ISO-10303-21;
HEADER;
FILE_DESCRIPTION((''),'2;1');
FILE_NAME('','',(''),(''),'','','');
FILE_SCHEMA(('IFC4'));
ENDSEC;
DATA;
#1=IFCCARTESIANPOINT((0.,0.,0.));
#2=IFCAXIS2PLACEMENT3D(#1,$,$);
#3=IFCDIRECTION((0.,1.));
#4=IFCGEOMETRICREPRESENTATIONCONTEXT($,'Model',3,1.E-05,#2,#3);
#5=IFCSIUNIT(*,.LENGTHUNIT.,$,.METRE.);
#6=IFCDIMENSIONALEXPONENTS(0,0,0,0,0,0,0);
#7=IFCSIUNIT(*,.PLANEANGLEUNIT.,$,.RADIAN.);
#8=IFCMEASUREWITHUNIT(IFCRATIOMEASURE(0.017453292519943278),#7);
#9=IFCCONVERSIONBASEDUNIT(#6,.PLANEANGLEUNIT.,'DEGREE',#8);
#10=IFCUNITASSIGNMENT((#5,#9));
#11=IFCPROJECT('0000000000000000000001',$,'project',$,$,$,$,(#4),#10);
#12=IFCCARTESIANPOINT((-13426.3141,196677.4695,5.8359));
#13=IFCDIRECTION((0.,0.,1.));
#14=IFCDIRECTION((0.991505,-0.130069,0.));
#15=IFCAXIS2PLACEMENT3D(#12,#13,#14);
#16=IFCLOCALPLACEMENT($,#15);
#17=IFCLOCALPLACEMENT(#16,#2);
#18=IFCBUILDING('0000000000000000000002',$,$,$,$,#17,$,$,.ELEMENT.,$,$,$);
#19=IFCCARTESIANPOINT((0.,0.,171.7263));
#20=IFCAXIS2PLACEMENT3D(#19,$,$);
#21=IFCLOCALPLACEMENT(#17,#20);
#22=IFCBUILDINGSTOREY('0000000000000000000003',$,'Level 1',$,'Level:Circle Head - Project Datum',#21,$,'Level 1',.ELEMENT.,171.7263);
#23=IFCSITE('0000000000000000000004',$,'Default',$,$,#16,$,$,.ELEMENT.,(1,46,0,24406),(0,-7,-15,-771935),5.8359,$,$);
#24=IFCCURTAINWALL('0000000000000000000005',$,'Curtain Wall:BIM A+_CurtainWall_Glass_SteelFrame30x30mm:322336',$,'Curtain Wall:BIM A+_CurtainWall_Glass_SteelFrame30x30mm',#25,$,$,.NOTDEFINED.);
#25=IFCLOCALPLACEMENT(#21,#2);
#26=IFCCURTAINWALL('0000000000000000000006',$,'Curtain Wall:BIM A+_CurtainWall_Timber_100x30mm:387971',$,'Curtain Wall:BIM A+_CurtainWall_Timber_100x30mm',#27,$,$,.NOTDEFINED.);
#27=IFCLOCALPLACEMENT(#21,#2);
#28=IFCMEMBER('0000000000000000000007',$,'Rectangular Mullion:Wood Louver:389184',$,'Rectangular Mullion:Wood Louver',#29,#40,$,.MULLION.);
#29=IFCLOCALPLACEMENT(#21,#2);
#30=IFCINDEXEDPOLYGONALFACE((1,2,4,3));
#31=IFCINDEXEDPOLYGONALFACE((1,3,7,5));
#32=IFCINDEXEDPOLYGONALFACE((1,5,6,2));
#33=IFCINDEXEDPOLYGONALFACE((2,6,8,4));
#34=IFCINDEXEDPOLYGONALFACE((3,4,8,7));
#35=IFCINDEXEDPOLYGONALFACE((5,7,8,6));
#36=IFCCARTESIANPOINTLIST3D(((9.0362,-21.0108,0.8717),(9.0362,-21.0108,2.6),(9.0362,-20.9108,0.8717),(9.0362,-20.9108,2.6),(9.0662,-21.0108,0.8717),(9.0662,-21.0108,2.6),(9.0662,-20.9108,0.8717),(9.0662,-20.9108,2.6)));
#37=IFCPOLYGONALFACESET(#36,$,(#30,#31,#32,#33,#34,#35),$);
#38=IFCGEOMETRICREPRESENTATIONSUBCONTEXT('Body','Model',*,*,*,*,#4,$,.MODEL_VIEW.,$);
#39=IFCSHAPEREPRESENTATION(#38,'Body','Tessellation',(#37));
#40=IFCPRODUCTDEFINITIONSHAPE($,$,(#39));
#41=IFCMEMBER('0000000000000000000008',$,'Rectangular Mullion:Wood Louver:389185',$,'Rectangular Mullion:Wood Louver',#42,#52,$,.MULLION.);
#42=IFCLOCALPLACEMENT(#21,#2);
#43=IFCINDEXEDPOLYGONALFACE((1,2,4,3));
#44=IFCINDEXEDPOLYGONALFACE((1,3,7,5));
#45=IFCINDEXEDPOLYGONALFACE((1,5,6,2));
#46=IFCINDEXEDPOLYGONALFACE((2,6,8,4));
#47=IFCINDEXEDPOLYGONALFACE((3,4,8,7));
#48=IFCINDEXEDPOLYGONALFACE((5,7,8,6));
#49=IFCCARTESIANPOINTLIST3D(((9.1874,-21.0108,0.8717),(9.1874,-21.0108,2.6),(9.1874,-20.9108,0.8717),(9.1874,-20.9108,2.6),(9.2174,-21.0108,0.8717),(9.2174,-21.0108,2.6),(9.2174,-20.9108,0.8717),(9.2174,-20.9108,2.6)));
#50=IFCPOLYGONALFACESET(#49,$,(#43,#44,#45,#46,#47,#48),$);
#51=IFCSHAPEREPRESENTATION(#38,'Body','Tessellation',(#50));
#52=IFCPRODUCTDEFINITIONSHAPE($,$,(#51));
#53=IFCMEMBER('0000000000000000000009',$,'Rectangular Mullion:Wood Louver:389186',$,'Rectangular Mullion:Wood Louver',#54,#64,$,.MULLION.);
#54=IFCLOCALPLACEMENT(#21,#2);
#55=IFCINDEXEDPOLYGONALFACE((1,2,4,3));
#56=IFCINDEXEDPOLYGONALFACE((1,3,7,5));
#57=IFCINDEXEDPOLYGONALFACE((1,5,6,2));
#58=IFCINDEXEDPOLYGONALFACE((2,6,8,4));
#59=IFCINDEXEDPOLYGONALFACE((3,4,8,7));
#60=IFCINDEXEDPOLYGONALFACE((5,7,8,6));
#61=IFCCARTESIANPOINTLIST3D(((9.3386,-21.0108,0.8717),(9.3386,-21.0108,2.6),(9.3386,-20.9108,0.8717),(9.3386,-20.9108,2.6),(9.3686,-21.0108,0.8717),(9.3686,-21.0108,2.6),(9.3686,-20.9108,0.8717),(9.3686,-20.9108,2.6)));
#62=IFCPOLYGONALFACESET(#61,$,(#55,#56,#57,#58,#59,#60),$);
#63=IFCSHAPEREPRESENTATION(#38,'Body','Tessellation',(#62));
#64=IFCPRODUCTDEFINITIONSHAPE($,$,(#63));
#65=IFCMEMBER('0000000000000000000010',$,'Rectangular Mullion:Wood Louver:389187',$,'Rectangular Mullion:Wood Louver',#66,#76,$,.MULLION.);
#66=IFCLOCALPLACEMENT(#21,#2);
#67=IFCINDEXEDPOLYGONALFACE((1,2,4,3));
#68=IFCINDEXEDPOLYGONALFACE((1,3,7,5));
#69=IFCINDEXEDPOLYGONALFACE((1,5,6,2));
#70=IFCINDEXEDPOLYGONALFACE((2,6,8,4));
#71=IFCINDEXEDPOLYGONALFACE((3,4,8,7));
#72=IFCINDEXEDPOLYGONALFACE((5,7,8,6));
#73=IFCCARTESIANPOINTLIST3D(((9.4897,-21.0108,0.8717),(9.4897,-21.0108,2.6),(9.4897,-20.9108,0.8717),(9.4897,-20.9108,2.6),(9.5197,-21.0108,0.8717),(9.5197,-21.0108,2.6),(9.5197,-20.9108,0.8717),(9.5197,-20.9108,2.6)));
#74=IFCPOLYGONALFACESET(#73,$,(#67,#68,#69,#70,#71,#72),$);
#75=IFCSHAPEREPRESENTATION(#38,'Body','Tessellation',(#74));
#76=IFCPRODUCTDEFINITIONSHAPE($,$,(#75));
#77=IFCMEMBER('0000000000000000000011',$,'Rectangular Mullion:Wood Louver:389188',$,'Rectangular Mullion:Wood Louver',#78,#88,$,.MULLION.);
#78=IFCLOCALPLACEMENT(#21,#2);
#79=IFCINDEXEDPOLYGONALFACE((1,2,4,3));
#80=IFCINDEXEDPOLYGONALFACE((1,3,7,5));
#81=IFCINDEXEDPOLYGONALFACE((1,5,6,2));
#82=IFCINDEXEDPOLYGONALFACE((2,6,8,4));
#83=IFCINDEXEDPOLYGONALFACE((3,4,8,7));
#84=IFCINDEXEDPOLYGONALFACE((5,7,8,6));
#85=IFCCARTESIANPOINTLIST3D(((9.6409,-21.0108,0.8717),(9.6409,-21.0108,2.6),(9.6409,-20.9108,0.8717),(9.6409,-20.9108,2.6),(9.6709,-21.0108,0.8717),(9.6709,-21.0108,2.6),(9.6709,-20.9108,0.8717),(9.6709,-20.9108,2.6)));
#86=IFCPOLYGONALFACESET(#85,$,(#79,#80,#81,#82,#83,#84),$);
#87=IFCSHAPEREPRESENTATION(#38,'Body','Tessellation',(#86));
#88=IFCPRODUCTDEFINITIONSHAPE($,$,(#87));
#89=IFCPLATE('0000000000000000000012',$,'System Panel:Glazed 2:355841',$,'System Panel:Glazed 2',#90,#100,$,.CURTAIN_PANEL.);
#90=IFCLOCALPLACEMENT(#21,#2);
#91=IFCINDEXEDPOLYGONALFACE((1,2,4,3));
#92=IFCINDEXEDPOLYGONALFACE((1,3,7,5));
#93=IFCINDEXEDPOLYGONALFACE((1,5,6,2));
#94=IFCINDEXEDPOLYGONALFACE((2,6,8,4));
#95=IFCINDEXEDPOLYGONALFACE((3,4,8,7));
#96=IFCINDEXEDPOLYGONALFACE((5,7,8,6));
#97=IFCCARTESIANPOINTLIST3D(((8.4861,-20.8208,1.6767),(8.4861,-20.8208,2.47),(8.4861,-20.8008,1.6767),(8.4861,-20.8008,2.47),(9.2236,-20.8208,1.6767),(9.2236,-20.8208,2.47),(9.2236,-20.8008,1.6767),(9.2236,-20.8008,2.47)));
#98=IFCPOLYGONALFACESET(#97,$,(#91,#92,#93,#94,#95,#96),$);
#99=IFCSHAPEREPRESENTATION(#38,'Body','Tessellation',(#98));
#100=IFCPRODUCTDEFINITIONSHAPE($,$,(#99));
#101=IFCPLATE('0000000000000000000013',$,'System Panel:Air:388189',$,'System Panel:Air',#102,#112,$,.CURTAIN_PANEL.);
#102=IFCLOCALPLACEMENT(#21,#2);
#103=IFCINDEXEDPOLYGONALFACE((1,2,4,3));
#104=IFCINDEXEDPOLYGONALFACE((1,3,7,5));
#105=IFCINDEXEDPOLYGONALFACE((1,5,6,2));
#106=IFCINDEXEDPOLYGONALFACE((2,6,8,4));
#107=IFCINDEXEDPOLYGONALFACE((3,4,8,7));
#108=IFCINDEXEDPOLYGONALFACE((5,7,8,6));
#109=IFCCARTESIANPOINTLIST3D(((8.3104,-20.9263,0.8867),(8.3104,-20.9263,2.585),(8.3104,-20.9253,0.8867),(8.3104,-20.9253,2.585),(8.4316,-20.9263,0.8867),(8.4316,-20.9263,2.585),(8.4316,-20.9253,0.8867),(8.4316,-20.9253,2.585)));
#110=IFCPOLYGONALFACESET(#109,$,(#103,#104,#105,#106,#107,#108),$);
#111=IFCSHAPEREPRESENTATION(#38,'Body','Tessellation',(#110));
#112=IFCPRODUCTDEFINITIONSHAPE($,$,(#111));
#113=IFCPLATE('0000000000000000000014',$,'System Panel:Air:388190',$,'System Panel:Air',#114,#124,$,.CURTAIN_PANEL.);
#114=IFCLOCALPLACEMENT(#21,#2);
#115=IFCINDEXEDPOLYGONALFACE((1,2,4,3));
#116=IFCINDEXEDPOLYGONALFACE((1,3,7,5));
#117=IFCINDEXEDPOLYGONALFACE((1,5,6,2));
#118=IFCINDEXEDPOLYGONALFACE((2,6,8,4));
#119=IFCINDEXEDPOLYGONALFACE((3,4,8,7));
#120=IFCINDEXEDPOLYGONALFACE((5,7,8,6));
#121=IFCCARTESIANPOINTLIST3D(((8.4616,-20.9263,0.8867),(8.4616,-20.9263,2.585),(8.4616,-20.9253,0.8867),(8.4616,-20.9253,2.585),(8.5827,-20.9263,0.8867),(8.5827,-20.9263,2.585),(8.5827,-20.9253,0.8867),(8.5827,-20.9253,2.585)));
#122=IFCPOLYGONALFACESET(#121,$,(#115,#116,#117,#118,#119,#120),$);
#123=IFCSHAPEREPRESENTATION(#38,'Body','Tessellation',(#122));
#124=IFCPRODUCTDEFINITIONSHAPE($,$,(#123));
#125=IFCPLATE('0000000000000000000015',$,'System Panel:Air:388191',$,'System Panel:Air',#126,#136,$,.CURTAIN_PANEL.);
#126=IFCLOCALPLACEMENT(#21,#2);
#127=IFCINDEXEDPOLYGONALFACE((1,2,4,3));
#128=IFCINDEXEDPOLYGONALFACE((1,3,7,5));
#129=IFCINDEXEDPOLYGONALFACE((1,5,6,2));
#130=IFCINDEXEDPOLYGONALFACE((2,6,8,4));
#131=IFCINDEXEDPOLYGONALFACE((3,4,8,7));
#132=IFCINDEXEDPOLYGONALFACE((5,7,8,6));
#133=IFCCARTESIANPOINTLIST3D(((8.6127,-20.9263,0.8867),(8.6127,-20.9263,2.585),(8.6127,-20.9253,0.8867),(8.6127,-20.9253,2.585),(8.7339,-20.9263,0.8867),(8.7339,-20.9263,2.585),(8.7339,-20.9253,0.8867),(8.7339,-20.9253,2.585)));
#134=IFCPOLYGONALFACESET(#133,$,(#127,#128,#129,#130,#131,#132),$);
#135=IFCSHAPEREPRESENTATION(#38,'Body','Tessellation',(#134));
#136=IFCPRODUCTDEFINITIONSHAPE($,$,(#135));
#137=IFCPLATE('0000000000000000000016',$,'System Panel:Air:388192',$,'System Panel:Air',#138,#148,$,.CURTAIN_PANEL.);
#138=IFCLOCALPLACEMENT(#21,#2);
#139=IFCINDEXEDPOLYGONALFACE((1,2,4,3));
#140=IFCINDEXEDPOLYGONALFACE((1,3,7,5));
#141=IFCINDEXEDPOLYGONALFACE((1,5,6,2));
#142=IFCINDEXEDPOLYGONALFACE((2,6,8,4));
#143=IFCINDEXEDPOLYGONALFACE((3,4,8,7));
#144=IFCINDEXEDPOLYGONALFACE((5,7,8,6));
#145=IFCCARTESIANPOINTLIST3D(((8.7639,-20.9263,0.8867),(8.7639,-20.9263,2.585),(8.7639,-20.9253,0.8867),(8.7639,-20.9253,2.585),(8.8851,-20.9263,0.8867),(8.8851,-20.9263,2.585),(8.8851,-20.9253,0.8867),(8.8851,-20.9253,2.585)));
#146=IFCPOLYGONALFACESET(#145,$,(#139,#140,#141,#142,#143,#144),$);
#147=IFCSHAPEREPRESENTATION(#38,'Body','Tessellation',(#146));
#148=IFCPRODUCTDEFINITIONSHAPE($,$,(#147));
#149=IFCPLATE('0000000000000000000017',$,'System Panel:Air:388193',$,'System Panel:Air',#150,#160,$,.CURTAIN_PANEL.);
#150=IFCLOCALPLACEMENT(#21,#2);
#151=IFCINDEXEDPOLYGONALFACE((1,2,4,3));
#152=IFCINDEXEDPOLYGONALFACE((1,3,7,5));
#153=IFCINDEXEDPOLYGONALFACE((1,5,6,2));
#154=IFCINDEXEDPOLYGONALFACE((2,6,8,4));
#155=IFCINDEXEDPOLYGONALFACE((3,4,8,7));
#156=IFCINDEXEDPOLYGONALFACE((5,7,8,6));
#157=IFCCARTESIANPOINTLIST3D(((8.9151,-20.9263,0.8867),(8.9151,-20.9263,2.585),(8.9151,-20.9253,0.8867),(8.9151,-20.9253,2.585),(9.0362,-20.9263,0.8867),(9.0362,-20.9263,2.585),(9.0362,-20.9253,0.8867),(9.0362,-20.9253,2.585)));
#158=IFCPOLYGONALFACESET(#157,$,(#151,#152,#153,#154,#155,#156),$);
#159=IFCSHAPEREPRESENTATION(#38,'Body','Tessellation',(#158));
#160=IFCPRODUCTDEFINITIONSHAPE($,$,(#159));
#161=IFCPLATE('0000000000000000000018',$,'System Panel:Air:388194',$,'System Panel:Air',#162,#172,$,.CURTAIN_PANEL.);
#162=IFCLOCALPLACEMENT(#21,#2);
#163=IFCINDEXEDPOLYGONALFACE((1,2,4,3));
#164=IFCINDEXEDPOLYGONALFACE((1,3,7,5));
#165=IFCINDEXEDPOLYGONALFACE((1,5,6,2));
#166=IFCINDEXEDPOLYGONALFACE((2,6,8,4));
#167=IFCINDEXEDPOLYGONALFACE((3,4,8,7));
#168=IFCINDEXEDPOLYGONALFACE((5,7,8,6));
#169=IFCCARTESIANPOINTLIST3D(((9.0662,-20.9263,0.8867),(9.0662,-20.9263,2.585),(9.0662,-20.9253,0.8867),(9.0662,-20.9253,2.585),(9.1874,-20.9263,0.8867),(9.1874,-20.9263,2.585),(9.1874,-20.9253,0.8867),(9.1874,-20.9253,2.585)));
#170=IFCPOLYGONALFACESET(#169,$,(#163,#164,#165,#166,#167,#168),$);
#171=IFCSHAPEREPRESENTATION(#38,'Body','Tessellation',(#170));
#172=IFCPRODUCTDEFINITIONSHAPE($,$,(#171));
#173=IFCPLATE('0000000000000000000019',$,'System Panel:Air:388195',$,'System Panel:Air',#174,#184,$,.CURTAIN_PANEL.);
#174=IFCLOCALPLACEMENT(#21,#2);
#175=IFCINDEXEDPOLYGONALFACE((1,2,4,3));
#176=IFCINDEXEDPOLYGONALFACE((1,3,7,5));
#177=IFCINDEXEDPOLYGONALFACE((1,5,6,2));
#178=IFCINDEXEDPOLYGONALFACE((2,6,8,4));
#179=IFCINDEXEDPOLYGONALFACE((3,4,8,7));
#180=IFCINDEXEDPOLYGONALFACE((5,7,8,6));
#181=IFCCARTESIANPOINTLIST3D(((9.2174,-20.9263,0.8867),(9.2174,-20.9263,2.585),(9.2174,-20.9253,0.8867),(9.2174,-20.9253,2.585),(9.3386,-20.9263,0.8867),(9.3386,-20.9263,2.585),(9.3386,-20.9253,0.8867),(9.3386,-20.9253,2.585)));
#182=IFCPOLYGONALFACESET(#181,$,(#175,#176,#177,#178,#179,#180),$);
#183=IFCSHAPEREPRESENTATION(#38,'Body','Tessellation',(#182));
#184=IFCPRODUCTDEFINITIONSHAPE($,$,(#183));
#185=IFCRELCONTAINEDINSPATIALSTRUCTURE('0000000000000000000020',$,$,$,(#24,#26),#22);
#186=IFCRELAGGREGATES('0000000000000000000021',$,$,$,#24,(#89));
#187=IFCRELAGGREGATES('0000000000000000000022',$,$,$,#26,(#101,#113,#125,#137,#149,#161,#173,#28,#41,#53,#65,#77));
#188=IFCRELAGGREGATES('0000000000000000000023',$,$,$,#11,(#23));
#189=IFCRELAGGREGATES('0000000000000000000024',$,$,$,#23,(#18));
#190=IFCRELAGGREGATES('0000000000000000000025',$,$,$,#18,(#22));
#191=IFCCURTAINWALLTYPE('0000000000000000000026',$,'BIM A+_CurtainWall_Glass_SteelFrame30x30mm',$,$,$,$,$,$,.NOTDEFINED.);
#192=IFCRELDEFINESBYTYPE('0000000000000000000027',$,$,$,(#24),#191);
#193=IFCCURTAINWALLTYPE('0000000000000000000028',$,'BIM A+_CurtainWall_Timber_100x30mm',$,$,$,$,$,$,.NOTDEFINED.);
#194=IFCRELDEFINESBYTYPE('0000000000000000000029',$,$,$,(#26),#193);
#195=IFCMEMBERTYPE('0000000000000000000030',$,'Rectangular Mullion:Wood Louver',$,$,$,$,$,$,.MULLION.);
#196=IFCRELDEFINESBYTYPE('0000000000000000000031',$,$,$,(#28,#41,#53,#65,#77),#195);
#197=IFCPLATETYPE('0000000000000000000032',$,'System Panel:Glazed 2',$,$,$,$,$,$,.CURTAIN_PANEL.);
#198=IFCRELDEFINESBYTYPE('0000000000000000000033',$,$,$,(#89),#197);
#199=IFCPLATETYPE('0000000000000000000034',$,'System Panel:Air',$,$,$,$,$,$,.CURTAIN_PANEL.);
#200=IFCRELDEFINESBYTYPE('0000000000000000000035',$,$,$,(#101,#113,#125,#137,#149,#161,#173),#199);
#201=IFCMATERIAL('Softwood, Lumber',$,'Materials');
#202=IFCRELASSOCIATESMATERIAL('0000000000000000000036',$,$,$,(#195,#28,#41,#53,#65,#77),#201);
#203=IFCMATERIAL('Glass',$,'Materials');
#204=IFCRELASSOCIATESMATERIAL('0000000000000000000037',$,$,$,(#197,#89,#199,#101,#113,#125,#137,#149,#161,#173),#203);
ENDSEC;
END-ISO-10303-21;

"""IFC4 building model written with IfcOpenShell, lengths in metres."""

from ifc_helpers import new_model, entity, si_unit, converted_unit, direction, frame, origin, place, context, subcontext, project, spatial, indexed_curve, outline, extrude, source, transform, mapped, material, type_object, type_shapes, element, aggregate, save


model = new_model("IFC4")

# Units and contexts
model_context = context("Model", 3, precision=1e-05, world=origin(), true_north=direction((0.0, 1.0)))
body_context = subcontext(model_context, "Body", "Model", "MODEL_VIEW")
ifc_project = project(units=[si_unit("LENGTHUNIT", "METRE"), converted_unit("PLANEANGLEUNIT", "DEGREE", entity("IfcRatioMeasure", 0.017453292519943278), si_unit("PLANEANGLEUNIT", "RADIAN"), dimensions=[0, 0, 0, 0, 0, 0, 0])], contexts=[model_context])

# Site, building, storey
site_placement = place(None, frame((-13426.3141, 196677.4695, 5.8359), z_axis=(0.0, 0.0, 1.0), x_axis=(0.991505, -0.130069, 0.0)))
site = spatial("IfcSite", under=ifc_project, at=site_placement, Name="Default", CompositionType="ELEMENT", RefLatitude=(1, 46, 0, 24406), RefLongitude=(0, -7, -15, -771935), RefElevation=5.8359)
building_placement = place(site_placement, origin())
building = spatial("IfcBuilding", under=site, at=building_placement, CompositionType="ELEMENT")
storey_placement = place(building_placement, frame((0.0, 0.0, 171.7263)))
storey = spatial("IfcBuildingStorey", under=building, at=storey_placement, Name="Level 1", ObjectType="Level:Circle Head - Project Datum", LongName="Level 1", CompositionType="ELEMENT", Elevation=171.7263)

# Curtain wall
curtain_wall_type_1 = type_object("IfcCurtainWallType", Name="BIM A+_CurtainWall_Glass_SteelFrame30x30mm", PredefinedType="NOTDEFINED")
curtain_wall_1_placement = place(storey_placement, frame((0.0, 0.0, -171.7263)))
curtain_wall_1 = element("IfcCurtainWall", 1, at=curtain_wall_1_placement, inside=storey, type_object=curtain_wall_type_1, Name="Curtain Wall:BIM A+_CurtainWall_Glass_SteelFrame30x30mm:322336", ObjectType="Curtain Wall:BIM A+_CurtainWall_Glass_SteelFrame30x30mm", PredefinedType="NOTDEFINED")

# Curtain wall, members
curtain_wall_type_2 = type_object("IfcCurtainWallType", Name="BIM A+_CurtainWall_Timber_100x30mm", PredefinedType="NOTDEFINED")
curtain_wall_2_placement = place(storey_placement, frame((0.0, 0.0, -171.7263)))
curtain_wall_2 = element("IfcCurtainWall", 2, at=curtain_wall_2_placement, inside=storey, type_object=curtain_wall_type_2, Name="Curtain Wall:BIM A+_CurtainWall_Timber_100x30mm:387971", ObjectType="Curtain Wall:BIM A+_CurtainWall_Timber_100x30mm", PredefinedType="NOTDEFINED")
ifc_material_1 = material(Name="Softwood, Lumber", Category="Materials")
member_type_1 = type_object("IfcMemberType", Name="Rectangular Mullion:Wood Louver", PredefinedType="MULLION", material=ifc_material_1)
shared_shape_1 = source(origin(), body_context, "Body", "SweptSolid", [
    extrude(outline(indexed_curve([(-0.05, -0.015), (0.05, -0.015), (0.05, 0.015), (-0.05, 0.015), (-0.05, -0.015)], self_intersect=False)), frame((0.0, 0.035, -1.7283), z_axis=(0.0, 0.0, 1.0), x_axis=(0.0, -1.0, 0.0)), (0.0, 0.0, 1.0), 1.7283),
])
type_shapes(member_type_1, [shared_shape_1])
member_1_placement = place(curtain_wall_2_placement, frame((9.0512, -20.9258, 172.598), z_axis=(0.0, 0.0, -1.0), x_axis=(1.0, 0.0, 0.0)))
member_1 = element("IfcMember", 3, at=member_1_placement, type_object=member_type_1, material=ifc_material_1, Name="Rectangular Mullion:Wood Louver:389184", ObjectType="Rectangular Mullion:Wood Louver", PredefinedType="MULLION", context=body_context, shape_type="MappedRepresentation", body=[
    mapped(shared_shape_1, transform((0.0, 0.0, 0.0), scale=1.0)),
])
member_2_placement = place(curtain_wall_2_placement, frame((9.2024, -20.9258, 172.598), z_axis=(0.0, 0.0, -1.0), x_axis=(1.0, 0.0, 0.0)))
member_2 = element("IfcMember", 4, at=member_2_placement, type_object=member_type_1, material=ifc_material_1, Name="Rectangular Mullion:Wood Louver:389185", ObjectType="Rectangular Mullion:Wood Louver", PredefinedType="MULLION", context=body_context, shape_type="MappedRepresentation", body=[
    mapped(shared_shape_1, transform((0.0, 0.0, 0.0), scale=1.0)),
])
member_3_placement = place(curtain_wall_2_placement, frame((9.3536, -20.9258, 172.598), z_axis=(0.0, 0.0, -1.0), x_axis=(1.0, 0.0, 0.0)))
member_3 = element("IfcMember", 5, at=member_3_placement, type_object=member_type_1, material=ifc_material_1, Name="Rectangular Mullion:Wood Louver:389186", ObjectType="Rectangular Mullion:Wood Louver", PredefinedType="MULLION", context=body_context, shape_type="MappedRepresentation", body=[
    mapped(shared_shape_1, transform((0.0, 0.0, 0.0), scale=1.0)),
])
member_4_placement = place(curtain_wall_2_placement, frame((9.5047, -20.9258, 172.598), z_axis=(0.0, 0.0, -1.0), x_axis=(1.0, 0.0, 0.0)))
member_4 = element("IfcMember", 6, at=member_4_placement, type_object=member_type_1, material=ifc_material_1, Name="Rectangular Mullion:Wood Louver:389187", ObjectType="Rectangular Mullion:Wood Louver", PredefinedType="MULLION", context=body_context, shape_type="MappedRepresentation", body=[
    mapped(shared_shape_1, transform((0.0, 0.0, 0.0), scale=1.0)),
])
member_5_placement = place(curtain_wall_2_placement, frame((9.6559, -20.9258, 172.598), z_axis=(0.0, 0.0, -1.0), x_axis=(1.0, 0.0, 0.0)))
member_5 = element("IfcMember", 7, at=member_5_placement, type_object=member_type_1, material=ifc_material_1, Name="Rectangular Mullion:Wood Louver:389188", ObjectType="Rectangular Mullion:Wood Louver", PredefinedType="MULLION", context=body_context, shape_type="MappedRepresentation", body=[
    mapped(shared_shape_1, transform((0.0, 0.0, 0.0), scale=1.0)),
])

# Plates
ifc_material_2 = material(Name="Glass", Category="Materials")
plate_type_1 = type_object("IfcPlateType", Name="System Panel:Glazed 2", PredefinedType="CURTAIN_PANEL", material=ifc_material_2)
shared_shape_2 = source(origin(), body_context, "Body", "SweptSolid", [
    extrude(outline(indexed_curve([(-0.01, -0.3688), (0.01, -0.3688), (0.01, 0.3688), (-0.01, 0.3688), (-0.01, -0.3688)], self_intersect=False)), frame((0.0, 0.0, 0.0), z_axis=(0.0, 0.0, 1.0), x_axis=(0.0, 1.0, 0.0)), (0.0, 0.0, 1.0), 0.7933),
])
type_shapes(plate_type_1, [shared_shape_2])
plate_1_placement = place(curtain_wall_1_placement, frame((8.8548, -20.8108, 173.4029)))
plate_1 = element("IfcPlate", 8, at=plate_1_placement, type_object=plate_type_1, material=ifc_material_2, Name="System Panel:Glazed 2:355841", ObjectType="System Panel:Glazed 2", PredefinedType="CURTAIN_PANEL", context=body_context, shape_type="MappedRepresentation", body=[
    mapped(shared_shape_2, transform((0.0, 0.0, 0.0), scale=1.0)),
])
aggregate(curtain_wall_1, [plate_1])
plate_type_2 = type_object("IfcPlateType", Name="System Panel:Air", PredefinedType="CURTAIN_PANEL", material=ifc_material_2)
shared_shape_3 = source(origin(), body_context, "Body", "SweptSolid", [
    extrude(outline(indexed_curve([(-0.0005, -0.0606), (0.0005, -0.0606), (0.0005, 0.0606), (-0.0005, 0.0606), (-0.0005, -0.0606)], self_intersect=False)), frame((0.0, 0.0, 0.0), z_axis=(0.0, 0.0, 1.0), x_axis=(0.0, 1.0, 0.0)), (0.0, 0.0, 1.0), 1.6983),
])
type_shapes(plate_type_2, [shared_shape_3])
plate_2_placement = place(curtain_wall_2_placement, frame((8.371, -20.9258, 172.613)))
plate_2 = element("IfcPlate", 9, at=plate_2_placement, type_object=plate_type_2, material=ifc_material_2, Name="System Panel:Air:388189", ObjectType="System Panel:Air", PredefinedType="CURTAIN_PANEL", context=body_context, shape_type="MappedRepresentation", body=[
    mapped(shared_shape_3, transform((0.0, 0.0, 0.0), scale=1.0)),
])
plate_3_placement = place(curtain_wall_2_placement, frame((8.5222, -20.9258, 172.613)))
plate_3 = element("IfcPlate", 10, at=plate_3_placement, type_object=plate_type_2, material=ifc_material_2, Name="System Panel:Air:388190", ObjectType="System Panel:Air", PredefinedType="CURTAIN_PANEL", context=body_context, shape_type="MappedRepresentation", body=[
    mapped(shared_shape_3, transform((0.0, 0.0, 0.0), scale=1.0)),
])
plate_4_placement = place(curtain_wall_2_placement, frame((8.6733, -20.9258, 172.613)))
plate_4 = element("IfcPlate", 11, at=plate_4_placement, type_object=plate_type_2, material=ifc_material_2, Name="System Panel:Air:388191", ObjectType="System Panel:Air", PredefinedType="CURTAIN_PANEL", context=body_context, shape_type="MappedRepresentation", body=[
    mapped(shared_shape_3, transform((0.0, 0.0, 0.0), scale=1.0)),
])
plate_5_placement = place(curtain_wall_2_placement, frame((8.8245, -20.9258, 172.613)))
plate_5 = element("IfcPlate", 12, at=plate_5_placement, type_object=plate_type_2, material=ifc_material_2, Name="System Panel:Air:388192", ObjectType="System Panel:Air", PredefinedType="CURTAIN_PANEL", context=body_context, shape_type="MappedRepresentation", body=[
    mapped(shared_shape_3, transform((0.0, 0.0, 0.0), scale=1.0)),
])
plate_6_placement = place(curtain_wall_2_placement, frame((8.9757, -20.9258, 172.613)))
plate_6 = element("IfcPlate", 13, at=plate_6_placement, type_object=plate_type_2, material=ifc_material_2, Name="System Panel:Air:388193", ObjectType="System Panel:Air", PredefinedType="CURTAIN_PANEL", context=body_context, shape_type="MappedRepresentation", body=[
    mapped(shared_shape_3, transform((0.0, 0.0, 0.0), scale=1.0)),
])
plate_7_placement = place(curtain_wall_2_placement, frame((9.1268, -20.9258, 172.613)))
plate_7 = element("IfcPlate", 14, at=plate_7_placement, type_object=plate_type_2, material=ifc_material_2, Name="System Panel:Air:388194", ObjectType="System Panel:Air", PredefinedType="CURTAIN_PANEL", context=body_context, shape_type="MappedRepresentation", body=[
    mapped(shared_shape_3, transform((0.0, 0.0, 0.0), scale=1.0)),
])
plate_8_placement = place(curtain_wall_2_placement, frame((9.278, -20.9258, 172.613)))
plate_8 = element("IfcPlate", 15, at=plate_8_placement, type_object=plate_type_2, material=ifc_material_2, Name="System Panel:Air:388195", ObjectType="System Panel:Air", PredefinedType="CURTAIN_PANEL", context=body_context, shape_type="MappedRepresentation", body=[
    mapped(shared_shape_3, transform((0.0, 0.0, 0.0), scale=1.0)),
])
aggregate(curtain_wall_2, [plate_2, plate_3, plate_4, plate_5, plate_6, plate_7, plate_8, member_1, member_2, member_3, member_4, member_5])

save(model, "model.ifc")
